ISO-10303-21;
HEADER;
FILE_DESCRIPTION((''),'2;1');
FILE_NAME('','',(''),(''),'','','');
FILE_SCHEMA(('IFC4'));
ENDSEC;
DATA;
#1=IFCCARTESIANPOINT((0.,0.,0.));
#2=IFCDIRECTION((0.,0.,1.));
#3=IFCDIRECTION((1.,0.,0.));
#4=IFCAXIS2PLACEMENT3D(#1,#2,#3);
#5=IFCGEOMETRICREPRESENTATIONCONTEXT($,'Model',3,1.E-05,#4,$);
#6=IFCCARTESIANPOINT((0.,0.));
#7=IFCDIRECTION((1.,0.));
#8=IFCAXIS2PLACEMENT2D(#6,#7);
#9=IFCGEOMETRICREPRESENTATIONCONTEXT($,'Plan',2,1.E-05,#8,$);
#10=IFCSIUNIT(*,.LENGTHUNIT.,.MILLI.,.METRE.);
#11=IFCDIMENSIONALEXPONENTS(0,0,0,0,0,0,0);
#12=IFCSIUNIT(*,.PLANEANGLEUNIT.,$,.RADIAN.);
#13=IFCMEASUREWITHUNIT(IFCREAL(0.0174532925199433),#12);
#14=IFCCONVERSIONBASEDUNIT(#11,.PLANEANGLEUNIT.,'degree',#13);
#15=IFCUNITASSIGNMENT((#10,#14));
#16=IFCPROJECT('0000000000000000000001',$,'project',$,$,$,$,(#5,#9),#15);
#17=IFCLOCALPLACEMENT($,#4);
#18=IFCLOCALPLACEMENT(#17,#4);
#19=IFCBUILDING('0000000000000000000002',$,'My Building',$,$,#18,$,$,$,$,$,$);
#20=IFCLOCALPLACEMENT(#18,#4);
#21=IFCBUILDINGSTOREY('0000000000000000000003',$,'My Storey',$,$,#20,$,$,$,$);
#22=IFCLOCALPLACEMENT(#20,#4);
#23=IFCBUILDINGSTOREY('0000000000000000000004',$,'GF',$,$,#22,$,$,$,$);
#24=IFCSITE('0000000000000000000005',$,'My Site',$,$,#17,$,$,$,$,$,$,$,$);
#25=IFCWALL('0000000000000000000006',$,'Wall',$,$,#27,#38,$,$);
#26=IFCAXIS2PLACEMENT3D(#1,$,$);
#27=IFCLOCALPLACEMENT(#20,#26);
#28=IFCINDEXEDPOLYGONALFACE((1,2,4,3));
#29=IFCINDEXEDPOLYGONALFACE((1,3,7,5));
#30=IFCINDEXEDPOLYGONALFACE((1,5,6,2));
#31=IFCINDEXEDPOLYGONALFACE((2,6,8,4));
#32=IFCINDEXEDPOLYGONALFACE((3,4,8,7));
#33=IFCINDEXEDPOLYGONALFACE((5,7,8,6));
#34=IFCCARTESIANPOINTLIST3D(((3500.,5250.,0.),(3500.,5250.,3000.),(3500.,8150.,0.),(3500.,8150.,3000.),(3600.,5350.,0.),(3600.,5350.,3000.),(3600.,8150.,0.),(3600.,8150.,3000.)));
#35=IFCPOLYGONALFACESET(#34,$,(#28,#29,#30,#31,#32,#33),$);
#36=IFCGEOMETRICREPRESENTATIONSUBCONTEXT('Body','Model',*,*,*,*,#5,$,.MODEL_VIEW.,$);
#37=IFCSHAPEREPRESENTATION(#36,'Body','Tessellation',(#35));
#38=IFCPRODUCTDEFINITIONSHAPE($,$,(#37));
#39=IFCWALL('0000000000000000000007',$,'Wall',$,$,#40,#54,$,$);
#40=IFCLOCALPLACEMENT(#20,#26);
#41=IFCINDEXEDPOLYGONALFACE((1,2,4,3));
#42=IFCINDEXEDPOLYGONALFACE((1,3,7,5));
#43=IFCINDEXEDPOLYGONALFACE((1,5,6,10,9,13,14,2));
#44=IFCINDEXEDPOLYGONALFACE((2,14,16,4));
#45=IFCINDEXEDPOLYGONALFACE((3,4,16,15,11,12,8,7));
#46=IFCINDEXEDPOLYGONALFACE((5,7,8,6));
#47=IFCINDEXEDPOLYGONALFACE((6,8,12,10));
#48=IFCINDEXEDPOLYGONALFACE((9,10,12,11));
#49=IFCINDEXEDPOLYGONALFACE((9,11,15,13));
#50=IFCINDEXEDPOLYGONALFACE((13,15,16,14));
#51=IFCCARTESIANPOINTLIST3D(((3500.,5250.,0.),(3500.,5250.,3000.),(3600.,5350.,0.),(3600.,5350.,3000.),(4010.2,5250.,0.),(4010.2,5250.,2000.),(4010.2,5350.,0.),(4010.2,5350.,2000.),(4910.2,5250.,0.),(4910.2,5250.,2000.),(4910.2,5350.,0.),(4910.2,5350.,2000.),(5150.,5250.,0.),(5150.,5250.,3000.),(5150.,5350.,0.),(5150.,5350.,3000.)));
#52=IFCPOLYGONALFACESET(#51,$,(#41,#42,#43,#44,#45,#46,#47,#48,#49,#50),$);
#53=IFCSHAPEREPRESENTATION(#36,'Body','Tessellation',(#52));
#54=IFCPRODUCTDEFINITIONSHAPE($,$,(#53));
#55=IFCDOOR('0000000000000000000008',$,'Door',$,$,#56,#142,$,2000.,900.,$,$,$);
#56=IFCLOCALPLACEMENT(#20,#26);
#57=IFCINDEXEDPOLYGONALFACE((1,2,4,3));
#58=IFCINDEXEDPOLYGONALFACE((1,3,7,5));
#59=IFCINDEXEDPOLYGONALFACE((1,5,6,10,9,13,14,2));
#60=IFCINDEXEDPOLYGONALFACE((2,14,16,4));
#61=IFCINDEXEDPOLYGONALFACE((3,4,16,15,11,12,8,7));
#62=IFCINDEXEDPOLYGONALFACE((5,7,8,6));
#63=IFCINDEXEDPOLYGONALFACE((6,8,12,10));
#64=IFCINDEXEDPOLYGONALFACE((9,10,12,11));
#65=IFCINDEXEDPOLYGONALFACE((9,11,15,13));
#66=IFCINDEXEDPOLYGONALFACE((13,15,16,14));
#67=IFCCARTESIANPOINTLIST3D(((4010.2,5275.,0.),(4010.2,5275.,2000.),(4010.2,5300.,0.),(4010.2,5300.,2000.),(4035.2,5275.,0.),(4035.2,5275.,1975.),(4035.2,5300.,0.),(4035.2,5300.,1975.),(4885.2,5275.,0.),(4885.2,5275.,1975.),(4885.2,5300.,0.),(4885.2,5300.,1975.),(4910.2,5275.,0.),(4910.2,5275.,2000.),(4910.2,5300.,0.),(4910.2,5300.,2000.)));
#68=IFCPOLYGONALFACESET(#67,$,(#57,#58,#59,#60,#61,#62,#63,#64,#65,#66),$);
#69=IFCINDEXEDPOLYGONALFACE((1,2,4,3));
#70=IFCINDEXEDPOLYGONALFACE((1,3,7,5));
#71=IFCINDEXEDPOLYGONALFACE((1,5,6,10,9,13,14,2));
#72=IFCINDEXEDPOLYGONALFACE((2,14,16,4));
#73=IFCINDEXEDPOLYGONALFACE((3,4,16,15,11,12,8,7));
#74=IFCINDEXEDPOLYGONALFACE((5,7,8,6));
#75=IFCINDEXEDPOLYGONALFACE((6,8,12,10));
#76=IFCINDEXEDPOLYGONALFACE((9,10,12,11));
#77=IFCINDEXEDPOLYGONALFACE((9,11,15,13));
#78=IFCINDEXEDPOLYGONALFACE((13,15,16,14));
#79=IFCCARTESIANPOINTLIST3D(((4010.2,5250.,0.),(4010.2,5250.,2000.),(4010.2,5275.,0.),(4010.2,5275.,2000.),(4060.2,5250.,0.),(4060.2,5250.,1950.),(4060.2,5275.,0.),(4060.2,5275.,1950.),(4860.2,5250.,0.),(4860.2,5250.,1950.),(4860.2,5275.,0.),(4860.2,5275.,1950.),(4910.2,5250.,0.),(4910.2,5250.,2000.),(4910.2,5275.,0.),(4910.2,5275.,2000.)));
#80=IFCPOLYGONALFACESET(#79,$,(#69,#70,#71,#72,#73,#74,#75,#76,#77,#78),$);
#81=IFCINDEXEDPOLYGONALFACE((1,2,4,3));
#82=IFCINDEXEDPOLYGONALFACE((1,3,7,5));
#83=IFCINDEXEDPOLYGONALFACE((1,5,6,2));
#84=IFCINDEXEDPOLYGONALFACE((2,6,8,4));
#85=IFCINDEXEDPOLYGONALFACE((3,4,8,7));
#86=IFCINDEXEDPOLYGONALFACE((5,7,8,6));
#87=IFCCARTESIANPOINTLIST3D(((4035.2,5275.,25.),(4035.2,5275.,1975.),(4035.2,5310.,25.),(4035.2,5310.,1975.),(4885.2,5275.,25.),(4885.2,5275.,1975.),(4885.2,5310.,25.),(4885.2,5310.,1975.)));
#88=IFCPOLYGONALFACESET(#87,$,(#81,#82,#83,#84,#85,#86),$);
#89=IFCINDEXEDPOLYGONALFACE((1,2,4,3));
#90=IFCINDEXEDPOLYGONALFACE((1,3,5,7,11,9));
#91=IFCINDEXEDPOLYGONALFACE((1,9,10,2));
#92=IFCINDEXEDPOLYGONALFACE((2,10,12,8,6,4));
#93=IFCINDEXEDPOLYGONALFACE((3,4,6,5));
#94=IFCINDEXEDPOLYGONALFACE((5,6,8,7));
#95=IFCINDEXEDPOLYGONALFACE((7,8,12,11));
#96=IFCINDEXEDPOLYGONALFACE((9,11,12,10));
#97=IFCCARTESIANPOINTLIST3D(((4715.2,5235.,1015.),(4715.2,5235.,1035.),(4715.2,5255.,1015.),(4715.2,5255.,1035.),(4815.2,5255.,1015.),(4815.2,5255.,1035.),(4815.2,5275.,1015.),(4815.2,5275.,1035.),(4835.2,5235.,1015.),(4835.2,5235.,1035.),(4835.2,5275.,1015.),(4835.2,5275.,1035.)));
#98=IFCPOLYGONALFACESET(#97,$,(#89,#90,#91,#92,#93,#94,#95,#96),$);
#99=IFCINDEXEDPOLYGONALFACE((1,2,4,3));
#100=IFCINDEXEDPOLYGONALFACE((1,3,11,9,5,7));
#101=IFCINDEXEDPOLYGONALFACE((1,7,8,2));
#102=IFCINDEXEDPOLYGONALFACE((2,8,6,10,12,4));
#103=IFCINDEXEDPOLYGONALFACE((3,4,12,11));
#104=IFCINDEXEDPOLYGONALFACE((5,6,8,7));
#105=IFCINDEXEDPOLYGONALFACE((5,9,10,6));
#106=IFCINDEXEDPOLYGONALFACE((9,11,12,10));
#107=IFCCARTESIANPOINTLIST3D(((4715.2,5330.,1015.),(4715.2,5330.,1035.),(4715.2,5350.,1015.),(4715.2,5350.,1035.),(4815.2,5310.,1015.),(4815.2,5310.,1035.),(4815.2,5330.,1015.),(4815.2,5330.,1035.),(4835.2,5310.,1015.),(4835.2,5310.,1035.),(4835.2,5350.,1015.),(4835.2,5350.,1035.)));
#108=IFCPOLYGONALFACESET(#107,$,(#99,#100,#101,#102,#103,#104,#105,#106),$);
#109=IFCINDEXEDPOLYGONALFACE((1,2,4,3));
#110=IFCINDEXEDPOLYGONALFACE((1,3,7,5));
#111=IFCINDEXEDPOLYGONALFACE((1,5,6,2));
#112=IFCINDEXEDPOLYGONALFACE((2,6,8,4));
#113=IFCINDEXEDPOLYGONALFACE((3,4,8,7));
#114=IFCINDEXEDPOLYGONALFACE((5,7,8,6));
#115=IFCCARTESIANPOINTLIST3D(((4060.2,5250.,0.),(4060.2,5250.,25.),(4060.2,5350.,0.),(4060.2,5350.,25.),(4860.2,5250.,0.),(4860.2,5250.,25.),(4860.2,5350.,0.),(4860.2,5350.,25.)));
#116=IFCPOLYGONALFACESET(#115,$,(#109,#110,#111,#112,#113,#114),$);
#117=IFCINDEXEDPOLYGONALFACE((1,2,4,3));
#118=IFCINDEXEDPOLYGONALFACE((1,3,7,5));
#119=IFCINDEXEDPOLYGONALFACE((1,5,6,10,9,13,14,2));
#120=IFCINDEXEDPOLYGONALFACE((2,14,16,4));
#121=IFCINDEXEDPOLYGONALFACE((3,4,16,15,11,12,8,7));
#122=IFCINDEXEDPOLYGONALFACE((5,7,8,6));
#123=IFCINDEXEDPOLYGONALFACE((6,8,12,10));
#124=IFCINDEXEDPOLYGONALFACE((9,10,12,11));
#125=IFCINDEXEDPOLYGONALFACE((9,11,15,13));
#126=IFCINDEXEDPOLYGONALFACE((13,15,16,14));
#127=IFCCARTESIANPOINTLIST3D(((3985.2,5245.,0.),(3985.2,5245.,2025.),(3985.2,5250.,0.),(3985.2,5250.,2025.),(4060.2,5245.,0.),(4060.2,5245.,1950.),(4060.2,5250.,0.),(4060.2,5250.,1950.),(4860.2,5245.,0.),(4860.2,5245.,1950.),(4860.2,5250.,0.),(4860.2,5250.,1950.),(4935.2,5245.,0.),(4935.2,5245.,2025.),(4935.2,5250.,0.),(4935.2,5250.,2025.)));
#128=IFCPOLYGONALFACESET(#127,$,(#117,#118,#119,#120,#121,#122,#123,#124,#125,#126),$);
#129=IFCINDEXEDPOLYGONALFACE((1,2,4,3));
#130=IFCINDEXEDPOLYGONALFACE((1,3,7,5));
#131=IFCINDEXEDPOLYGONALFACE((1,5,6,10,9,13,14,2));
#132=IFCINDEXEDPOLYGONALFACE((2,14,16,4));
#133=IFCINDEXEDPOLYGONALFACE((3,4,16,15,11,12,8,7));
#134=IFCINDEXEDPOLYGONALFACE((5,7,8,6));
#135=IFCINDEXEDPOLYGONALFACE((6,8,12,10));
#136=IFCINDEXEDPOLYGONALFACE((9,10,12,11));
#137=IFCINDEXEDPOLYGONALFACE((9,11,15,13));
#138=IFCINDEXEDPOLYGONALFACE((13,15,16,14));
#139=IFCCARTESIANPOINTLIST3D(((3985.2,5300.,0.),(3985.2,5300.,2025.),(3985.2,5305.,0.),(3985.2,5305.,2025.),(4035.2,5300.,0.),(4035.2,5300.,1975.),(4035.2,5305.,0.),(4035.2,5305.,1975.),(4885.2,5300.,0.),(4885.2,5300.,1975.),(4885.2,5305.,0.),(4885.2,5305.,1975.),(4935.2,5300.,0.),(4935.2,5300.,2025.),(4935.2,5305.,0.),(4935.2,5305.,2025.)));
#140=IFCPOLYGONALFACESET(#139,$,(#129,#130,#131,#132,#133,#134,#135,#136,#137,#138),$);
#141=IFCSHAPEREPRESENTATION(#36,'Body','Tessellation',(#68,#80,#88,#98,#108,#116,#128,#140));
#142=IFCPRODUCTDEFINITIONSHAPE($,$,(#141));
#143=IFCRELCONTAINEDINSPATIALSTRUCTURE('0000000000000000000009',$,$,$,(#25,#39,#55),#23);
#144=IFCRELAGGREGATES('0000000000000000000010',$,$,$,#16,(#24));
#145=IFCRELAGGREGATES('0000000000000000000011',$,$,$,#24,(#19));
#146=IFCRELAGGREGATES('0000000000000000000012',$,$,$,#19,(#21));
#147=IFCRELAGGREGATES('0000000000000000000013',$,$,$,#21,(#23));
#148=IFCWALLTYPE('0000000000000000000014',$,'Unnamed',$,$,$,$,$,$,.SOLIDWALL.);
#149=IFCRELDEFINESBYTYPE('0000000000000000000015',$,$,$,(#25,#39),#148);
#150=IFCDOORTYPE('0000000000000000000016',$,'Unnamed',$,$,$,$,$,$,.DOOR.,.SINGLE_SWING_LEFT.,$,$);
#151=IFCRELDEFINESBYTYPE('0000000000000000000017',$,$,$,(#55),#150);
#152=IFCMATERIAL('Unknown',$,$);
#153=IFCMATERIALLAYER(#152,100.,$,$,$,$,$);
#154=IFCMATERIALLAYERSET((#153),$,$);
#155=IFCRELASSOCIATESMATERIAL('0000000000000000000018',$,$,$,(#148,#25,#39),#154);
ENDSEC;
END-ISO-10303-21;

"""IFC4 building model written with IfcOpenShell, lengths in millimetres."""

from ifc_helpers import new_model, entity, si_unit, converted_unit, frame, origin_with_axes, origin_2d_with_axis, place, context, subcontext, project, spatial, line, indexed_curve, outline, extrude, shape, source, transform, mapped, material, layer, layer_set, layer_usage, type_object, type_shapes, element, fill, save


model = new_model("IFC4")

# Units and contexts
model_context = context("Model", 3, precision=1e-05, world=origin_with_axes())
plan_context = context("Plan", 2, precision=1e-05, world=origin_2d_with_axis())
body_context_1 = subcontext(model_context, "Body", "Model", "MODEL_VIEW")
body_context_2 = subcontext(plan_context, "Body", "Plan", "PLAN_VIEW")
ifc_project = project(units=[si_unit("LENGTHUNIT", "METRE", prefix="MILLI"), converted_unit("PLANEANGLEUNIT", "degree", entity("IfcReal", 0.0174532925199433), si_unit("PLANEANGLEUNIT", "RADIAN"), dimensions=[0, 0, 0, 0, 0, 0, 0])], contexts=[model_context, plan_context])

# Site, building, storeys
site_placement = place(None, origin_with_axes())
site = spatial("IfcSite", under=ifc_project, at=site_placement, Name="My Site")
building_placement = place(site_placement, origin_with_axes())
building = spatial("IfcBuilding", under=site, at=building_placement, Name="My Building")
storey_1_placement = place(building_placement, origin_with_axes())
storey_1 = spatial("IfcBuildingStorey", under=building, at=storey_1_placement, Name="My Storey")
storey_2_placement = place(storey_1_placement, origin_with_axes())
storey_2 = spatial("IfcBuildingStorey", under=storey_1, at=storey_2_placement, Name="GF")

# Wall
ifc_material = material(Name="Unknown")
ifc_layer_1 = layer(ifc_material, 100.0)
ifc_layer_set_1 = layer_set([ifc_layer_1])
ifc_layer_usage_1 = layer_usage(ifc_layer_set_1, "AXIS2", "POSITIVE", 0.0)
wall_type_1 = type_object("IfcWallType", Name="Unnamed", PredefinedType="SOLIDWALL", material=ifc_layer_set_1)
wall_1_placement = place(storey_2_placement, frame((3500.0, 8150.0, 0.0), z_axis=(0.0, 0.0, 1.0), x_axis=(0.0, -1.0, 0.0)))
element("IfcWall", 1, at=wall_1_placement, inside=storey_2, type_object=wall_type_1, material=ifc_layer_usage_1, Name="Wall", context=body_context_1, shape_type="SweptSolid", body=[
    extrude(outline(indexed_curve([(0.0, 0.0), (0.0, 100.0), (2800.0, 100.0), (2900.0, 0.0)], segments=[line(1, 2, 3, 4, 1)])), origin_with_axes(), (0.0, 0.0, 1.0), 3000.0),
])

# Wall, opening, door
ifc_layer_usage_2 = layer_usage(ifc_layer_set_1, "AXIS2", "POSITIVE", 0.0)
wall_2_placement = place(storey_2_placement, frame((3500.0, 5250.0, 0.0), z_axis=(0.0, 0.0, 1.0), x_axis=(1.0, 0.0, 0.0)))
wall_2 = element("IfcWall", 2, at=wall_2_placement, inside=storey_2, type_object=wall_type_1, material=ifc_layer_usage_2, Name="Wall", context=body_context_1, shape_type="SweptSolid", body=[
    extrude(outline(indexed_curve([(0.0, 0.0), (100.0, 100.0), (1650.0, 100.0), (1650.0, 0.0)], segments=[line(1, 2, 3, 4, 1)])), origin_with_axes(), (0.0, 0.0, 1.0), 3000.0),
])
shared_shape_1 = source(origin_with_axes(), body_context_1, "Body", "SweptSolid", [
    extrude(outline(indexed_curve([(0.0, 0.0), (900.0, 0.0), (900.0, 2000.0), (0.0, 2000.0)], segments=[line(1, 2, 3, 4, 1)])), frame((0.0, -600.0, 0.0), z_axis=(0.0, -1.0, 0.0), x_axis=(1.0, 0.0, 0.0)), (0.0, 0.0, -1.0), 1200.0),
])
opening_1_placement = place(wall_2_placement, frame((510.2, 0.0, 0.0), z_axis=(0.0, 0.0, 1.0), x_axis=(1.0, 0.0, 0.0)))
opening_1 = element("IfcOpeningElement", 3, at=opening_1_placement, cuts=wall_2, PredefinedType="OPENING", context=body_context_1, shape_type="MappedRepresentation", body=[
    mapped(shared_shape_1, transform((0.0, 0.0, 0.0), x_axis=(1.0, 0.0, 0.0), y_axis=(0.0, 1.0, 0.0), z_axis=(0.0, 0.0, 1.0), scale=1.0)),
])
door_type = type_object("IfcDoorType", Name="Unnamed", OperationType="SINGLE_SWING_LEFT", PredefinedType="DOOR")
shared_shape_2 = source(origin_with_axes(), body_context_1, "Body", "SweptSolid", [
    extrude(outline(indexed_curve([(0.0, 0.0), (0.0, 2000.0), (900.0, 2000.0), (900.0, 0.0), (875.0, 0.0), (875.0, 1975.0), (25.0, 1975.0), (25.0, 0.0)], segments=[line(1, 2, 3, 4, 5, 6, 7, 8, 1)])), frame((0.0, 25.0, 0.0), z_axis=(0.0, -1.0, 0.0), x_axis=(1.0, 0.0, 0.0)), (0.0, 0.0, -1.0), 25.0),
    extrude(outline(indexed_curve([(0.0, 0.0), (0.0, 2000.0), (900.0, 2000.0), (900.0, 0.0), (850.0, 0.0), (850.0, 1950.0), (50.0, 1950.0), (50.0, 0.0)], segments=[line(1, 2, 3, 4, 5, 6, 7, 8, 1)])), frame((0.0, 0.0, 0.0), z_axis=(0.0, -1.0, 0.0), x_axis=(1.0, 0.0, 0.0)), (0.0, 0.0, -1.0), 25.0),
    extrude(outline(indexed_curve([(0.0, 0.0), (850.0, 0.0), (850.0, 35.0), (0.0, 35.0)], segments=[line(1, 2, 3, 4, 1)])), frame((25.0, 25.0, 25.0), z_axis=(0.0, 0.0, 1.0), x_axis=(1.0, 0.0, 0.0)), (0.0, 0.0, 1.0), 1950.0),
    extrude(outline(indexed_curve([(0.0, 0.0), (0.0, -40.0), (-120.0, -40.0), (-120.0, -20.0), (-20.0, -20.0), (-20.0, 0.0)], segments=[line(1, 2, 3, 4, 5, 6, 1)])), frame((825.0, 25.0, 1015.0), z_axis=(0.0, 0.0, 1.0), x_axis=(1.0, 0.0, 0.0)), (0.0, 0.0, 1.0), 20.0),
    extrude(outline(indexed_curve([(0.0, 0.0), (0.0, 40.0), (-120.0, 40.0), (-120.0, 20.0), (-20.0, 20.0), (-20.0, 0.0)], segments=[line(1, 2, 3, 4, 5, 6, 1)])), frame((825.0, 60.0, 1015.0), z_axis=(0.0, 0.0, 1.0), x_axis=(1.0, 0.0, 0.0)), (0.0, 0.0, 1.0), 20.0),
    extrude(outline(indexed_curve([(0.0, 0.0), (800.0, 0.0), (800.0, 100.0), (0.0, 100.0)], segments=[line(1, 2, 3, 4, 1)])), frame((50.0, 0.0, 0.0), z_axis=(0.0, 0.0, 1.0), x_axis=(1.0, 0.0, 0.0)), (0.0, 0.0, 1.0), 25.0),
    extrude(outline(indexed_curve([(0.0, 0.0), (0.0, 2025.0), (950.0, 2025.0), (950.0, 0.0), (875.0, 0.0), (875.0, 1950.0), (75.0, 1950.0), (75.0, 0.0)], segments=[line(1, 2, 3, 4, 5, 6, 7, 8, 1)])), frame((-25.0, -5.0, 0.0), z_axis=(0.0, -1.0, 0.0), x_axis=(1.0, 0.0, 0.0)), (0.0, 0.0, -1.0), 5.0),
    extrude(outline(indexed_curve([(0.0, 0.0), (0.0, 2025.0), (950.0, 2025.0), (950.0, 0.0), (900.0, 0.0), (900.0, 1975.0), (50.0, 1975.0), (50.0, 0.0)], segments=[line(1, 2, 3, 4, 5, 6, 7, 8, 1)])), frame((-25.0, 50.0, 0.0), z_axis=(0.0, -1.0, 0.0), x_axis=(1.0, 0.0, 0.0)), (0.0, 0.0, -1.0), 5.0),
])
shared_shape_3 = source(origin_with_axes(), body_context_2, "Body", "Curve2D", [
    entity("IfcIndexedPolyCurve", entity("IfcCartesianPointList2D", [[0.0, 0.0], [0.0, 50.0], [25.0, 50.0], [25.0, 25.0], [50.0, 25.0], [50.0, 0.0]]), [entity("IfcLineIndex", [1, 2, 3, 4, 5, 6, 1])]),
    entity("IfcIndexedPolyCurve", entity("IfcCartesianPointList2D", [[900.0, 0.0], [900.0, 50.0], [875.0, 50.0], [875.0, 25.0], [850.0, 25.0], [850.0, 0.0]]), [entity("IfcLineIndex", [1, 2, 3, 4, 5, 6, 1])]),
    entity("IfcTrimmedCurve", entity("IfcEllipse", entity("IfcAxis2Placement2D", entity("IfcCartesianPoint", [60.0, 50.0]), entity("IfcDirection", [1.0, 0.0])), 815.0, 850.0), [entity("IfcCartesianPoint", [875.0, 50.0])], [entity("IfcCartesianPoint", [60.0, 900.0])], True, "CARTESIAN"),
    entity("IfcIndexedPolyCurve", entity("IfcCartesianPointList2D", [[25.0, 50.0], [60.0, 50.0], [60.0, 900.0], [25.0, 900.0]]), [entity("IfcLineIndex", [1, 2, 3, 4, 1])]),
])
type_shapes(door_type, [shared_shape_2, shared_shape_3])
door_1_placement = place(opening_1_placement, origin_with_axes())
door_1 = element("IfcDoor", 4, at=door_1_placement, inside=storey_2, type_object=door_type, Name="Door", OverallHeight=2000.0, OverallWidth=900.0, shapes=[
    shape(body_context_1, "Body", "MappedRepresentation", [mapped(shared_shape_2, transform((0.0, 0.0, 0.0), x_axis=(1.0, 0.0, 0.0), y_axis=(0.0, 1.0, 0.0), z_axis=(0.0, 0.0, 1.0), scale=1.0))]),
    shape(body_context_2, "Body", "MappedRepresentation", [mapped(shared_shape_3, transform((0.0, 0.0, 0.0), x_axis=(1.0, 0.0, 0.0), y_axis=(0.0, 1.0, 0.0), z_axis=(0.0, 0.0, 1.0), scale=1.0))]),
])
fill(opening_1, door_1)

save(model, "model.ifc")
